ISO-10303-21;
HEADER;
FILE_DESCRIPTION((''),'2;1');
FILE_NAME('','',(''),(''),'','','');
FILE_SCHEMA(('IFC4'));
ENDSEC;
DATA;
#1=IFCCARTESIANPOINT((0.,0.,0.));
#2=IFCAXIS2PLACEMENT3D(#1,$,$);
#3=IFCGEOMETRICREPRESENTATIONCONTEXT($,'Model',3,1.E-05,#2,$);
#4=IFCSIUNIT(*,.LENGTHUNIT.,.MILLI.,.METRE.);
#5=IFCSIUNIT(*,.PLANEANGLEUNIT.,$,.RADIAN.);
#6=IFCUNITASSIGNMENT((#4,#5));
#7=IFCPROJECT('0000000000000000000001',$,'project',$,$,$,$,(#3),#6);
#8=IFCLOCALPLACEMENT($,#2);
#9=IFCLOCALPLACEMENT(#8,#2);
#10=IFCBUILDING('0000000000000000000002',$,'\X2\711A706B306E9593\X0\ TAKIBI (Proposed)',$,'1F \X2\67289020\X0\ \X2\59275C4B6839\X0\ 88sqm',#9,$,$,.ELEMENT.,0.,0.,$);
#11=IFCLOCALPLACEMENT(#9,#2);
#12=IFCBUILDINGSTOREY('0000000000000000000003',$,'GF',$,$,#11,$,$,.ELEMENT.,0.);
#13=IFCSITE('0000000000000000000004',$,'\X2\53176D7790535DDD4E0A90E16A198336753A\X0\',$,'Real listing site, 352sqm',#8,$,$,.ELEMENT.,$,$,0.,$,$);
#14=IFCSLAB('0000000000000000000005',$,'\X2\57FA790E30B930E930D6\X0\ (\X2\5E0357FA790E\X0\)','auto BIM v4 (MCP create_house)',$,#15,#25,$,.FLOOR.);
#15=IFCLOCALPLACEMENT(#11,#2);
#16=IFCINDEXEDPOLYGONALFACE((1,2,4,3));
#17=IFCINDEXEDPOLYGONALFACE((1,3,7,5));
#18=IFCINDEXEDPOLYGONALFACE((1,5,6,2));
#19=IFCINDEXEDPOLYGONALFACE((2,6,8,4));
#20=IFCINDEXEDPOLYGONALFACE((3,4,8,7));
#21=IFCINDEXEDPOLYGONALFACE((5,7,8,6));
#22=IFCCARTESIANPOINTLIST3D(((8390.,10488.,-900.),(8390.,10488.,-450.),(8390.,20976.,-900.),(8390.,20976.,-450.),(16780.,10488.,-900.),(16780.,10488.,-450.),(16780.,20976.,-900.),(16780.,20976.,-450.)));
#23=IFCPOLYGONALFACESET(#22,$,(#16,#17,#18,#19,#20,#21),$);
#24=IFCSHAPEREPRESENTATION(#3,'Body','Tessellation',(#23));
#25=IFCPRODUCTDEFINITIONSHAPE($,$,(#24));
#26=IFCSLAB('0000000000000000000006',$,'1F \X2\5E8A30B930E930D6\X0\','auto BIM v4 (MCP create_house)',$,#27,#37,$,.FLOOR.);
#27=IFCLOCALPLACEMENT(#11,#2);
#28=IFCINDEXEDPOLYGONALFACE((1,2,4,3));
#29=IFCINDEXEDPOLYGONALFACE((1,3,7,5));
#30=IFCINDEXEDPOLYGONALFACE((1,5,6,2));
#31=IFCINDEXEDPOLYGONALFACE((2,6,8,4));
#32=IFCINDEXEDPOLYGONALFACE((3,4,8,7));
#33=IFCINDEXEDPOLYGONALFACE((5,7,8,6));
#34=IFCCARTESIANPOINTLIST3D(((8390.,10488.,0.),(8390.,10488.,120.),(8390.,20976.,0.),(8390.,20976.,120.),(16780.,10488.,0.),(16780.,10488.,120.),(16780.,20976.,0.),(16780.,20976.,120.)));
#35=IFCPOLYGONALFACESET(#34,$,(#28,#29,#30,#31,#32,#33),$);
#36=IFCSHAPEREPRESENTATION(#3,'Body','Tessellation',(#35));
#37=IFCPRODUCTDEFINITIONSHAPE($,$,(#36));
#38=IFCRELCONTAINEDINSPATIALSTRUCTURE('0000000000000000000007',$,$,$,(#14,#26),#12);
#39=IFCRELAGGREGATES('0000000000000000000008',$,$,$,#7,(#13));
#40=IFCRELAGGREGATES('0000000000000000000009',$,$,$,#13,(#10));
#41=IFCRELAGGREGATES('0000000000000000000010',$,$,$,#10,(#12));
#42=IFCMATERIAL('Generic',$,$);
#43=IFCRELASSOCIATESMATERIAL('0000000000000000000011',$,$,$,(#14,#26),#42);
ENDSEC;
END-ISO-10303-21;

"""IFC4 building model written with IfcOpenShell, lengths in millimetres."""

from ifc_helpers import new_model, si_unit, frame, frame_2d, origin, place, context, project, spatial, rectangle, extrude, material, element, save


model = new_model("IFC4")

# Units and contexts
model_context = context("Model", 3, precision=1e-05, world=origin())
ifc_project = project(units=[si_unit("LENGTHUNIT", "METRE", prefix="MILLI"), si_unit("PLANEANGLEUNIT", "RADIAN")], contexts=[model_context])

# Site, building, storey
site_placement = place(None, origin())
site = spatial("IfcSite", under=ifc_project, at=site_placement, Name="北海道川上郡標茶町", ObjectType="Real listing site, 352sqm", CompositionType="ELEMENT", RefElevation=0.0)
building_placement = place(site_placement, origin())
building = spatial("IfcBuilding", under=site, at=building_placement, Name="焚火の間 TAKIBI (Proposed)", ObjectType="1F 木造 大屋根 88sqm", CompositionType="ELEMENT", ElevationOfRefHeight=0.0, ElevationOfTerrain=0.0)
storey_placement = place(building_placement, origin())
storey = spatial("IfcBuildingStorey", under=building, at=storey_placement, Name="GF", CompositionType="ELEMENT", Elevation=0.0)

# Slabs
ifc_material = material(Name="Generic")
slab_1_placement = place(storey_placement, frame((4195.0, 5244.0, -450.0)))
element("IfcSlab", 1, at=slab_1_placement, inside=storey, material=ifc_material, Name="基礎スラブ (布基礎)", Description="auto BIM v4 (MCP create_house)", PredefinedType="FLOOR", context=model_context, shape_type="SweptSolid", body=[
    extrude(rectangle(XDim=8390.0, YDim=10488.0, at=frame_2d((4195.0, 5244.0))), frame((4195.0, 5244.0, -450.0)), (0.0, 0.0, 1.0), 450.0),
])
slab_2_placement = place(storey_placement, frame((4195.0, 5244.0, 0.0)))
element("IfcSlab", 2, at=slab_2_placement, inside=storey, material=ifc_material, Name="1F 床スラブ", Description="auto BIM v4 (MCP create_house)", PredefinedType="FLOOR", context=model_context, shape_type="SweptSolid", body=[
    extrude(rectangle(XDim=8390.0, YDim=10488.0, at=frame_2d((4195.0, 5244.0))), frame((4195.0, 5244.0, 0.0)), (0.0, 0.0, 1.0), 120.0),
])

save(model, "model.ifc")
